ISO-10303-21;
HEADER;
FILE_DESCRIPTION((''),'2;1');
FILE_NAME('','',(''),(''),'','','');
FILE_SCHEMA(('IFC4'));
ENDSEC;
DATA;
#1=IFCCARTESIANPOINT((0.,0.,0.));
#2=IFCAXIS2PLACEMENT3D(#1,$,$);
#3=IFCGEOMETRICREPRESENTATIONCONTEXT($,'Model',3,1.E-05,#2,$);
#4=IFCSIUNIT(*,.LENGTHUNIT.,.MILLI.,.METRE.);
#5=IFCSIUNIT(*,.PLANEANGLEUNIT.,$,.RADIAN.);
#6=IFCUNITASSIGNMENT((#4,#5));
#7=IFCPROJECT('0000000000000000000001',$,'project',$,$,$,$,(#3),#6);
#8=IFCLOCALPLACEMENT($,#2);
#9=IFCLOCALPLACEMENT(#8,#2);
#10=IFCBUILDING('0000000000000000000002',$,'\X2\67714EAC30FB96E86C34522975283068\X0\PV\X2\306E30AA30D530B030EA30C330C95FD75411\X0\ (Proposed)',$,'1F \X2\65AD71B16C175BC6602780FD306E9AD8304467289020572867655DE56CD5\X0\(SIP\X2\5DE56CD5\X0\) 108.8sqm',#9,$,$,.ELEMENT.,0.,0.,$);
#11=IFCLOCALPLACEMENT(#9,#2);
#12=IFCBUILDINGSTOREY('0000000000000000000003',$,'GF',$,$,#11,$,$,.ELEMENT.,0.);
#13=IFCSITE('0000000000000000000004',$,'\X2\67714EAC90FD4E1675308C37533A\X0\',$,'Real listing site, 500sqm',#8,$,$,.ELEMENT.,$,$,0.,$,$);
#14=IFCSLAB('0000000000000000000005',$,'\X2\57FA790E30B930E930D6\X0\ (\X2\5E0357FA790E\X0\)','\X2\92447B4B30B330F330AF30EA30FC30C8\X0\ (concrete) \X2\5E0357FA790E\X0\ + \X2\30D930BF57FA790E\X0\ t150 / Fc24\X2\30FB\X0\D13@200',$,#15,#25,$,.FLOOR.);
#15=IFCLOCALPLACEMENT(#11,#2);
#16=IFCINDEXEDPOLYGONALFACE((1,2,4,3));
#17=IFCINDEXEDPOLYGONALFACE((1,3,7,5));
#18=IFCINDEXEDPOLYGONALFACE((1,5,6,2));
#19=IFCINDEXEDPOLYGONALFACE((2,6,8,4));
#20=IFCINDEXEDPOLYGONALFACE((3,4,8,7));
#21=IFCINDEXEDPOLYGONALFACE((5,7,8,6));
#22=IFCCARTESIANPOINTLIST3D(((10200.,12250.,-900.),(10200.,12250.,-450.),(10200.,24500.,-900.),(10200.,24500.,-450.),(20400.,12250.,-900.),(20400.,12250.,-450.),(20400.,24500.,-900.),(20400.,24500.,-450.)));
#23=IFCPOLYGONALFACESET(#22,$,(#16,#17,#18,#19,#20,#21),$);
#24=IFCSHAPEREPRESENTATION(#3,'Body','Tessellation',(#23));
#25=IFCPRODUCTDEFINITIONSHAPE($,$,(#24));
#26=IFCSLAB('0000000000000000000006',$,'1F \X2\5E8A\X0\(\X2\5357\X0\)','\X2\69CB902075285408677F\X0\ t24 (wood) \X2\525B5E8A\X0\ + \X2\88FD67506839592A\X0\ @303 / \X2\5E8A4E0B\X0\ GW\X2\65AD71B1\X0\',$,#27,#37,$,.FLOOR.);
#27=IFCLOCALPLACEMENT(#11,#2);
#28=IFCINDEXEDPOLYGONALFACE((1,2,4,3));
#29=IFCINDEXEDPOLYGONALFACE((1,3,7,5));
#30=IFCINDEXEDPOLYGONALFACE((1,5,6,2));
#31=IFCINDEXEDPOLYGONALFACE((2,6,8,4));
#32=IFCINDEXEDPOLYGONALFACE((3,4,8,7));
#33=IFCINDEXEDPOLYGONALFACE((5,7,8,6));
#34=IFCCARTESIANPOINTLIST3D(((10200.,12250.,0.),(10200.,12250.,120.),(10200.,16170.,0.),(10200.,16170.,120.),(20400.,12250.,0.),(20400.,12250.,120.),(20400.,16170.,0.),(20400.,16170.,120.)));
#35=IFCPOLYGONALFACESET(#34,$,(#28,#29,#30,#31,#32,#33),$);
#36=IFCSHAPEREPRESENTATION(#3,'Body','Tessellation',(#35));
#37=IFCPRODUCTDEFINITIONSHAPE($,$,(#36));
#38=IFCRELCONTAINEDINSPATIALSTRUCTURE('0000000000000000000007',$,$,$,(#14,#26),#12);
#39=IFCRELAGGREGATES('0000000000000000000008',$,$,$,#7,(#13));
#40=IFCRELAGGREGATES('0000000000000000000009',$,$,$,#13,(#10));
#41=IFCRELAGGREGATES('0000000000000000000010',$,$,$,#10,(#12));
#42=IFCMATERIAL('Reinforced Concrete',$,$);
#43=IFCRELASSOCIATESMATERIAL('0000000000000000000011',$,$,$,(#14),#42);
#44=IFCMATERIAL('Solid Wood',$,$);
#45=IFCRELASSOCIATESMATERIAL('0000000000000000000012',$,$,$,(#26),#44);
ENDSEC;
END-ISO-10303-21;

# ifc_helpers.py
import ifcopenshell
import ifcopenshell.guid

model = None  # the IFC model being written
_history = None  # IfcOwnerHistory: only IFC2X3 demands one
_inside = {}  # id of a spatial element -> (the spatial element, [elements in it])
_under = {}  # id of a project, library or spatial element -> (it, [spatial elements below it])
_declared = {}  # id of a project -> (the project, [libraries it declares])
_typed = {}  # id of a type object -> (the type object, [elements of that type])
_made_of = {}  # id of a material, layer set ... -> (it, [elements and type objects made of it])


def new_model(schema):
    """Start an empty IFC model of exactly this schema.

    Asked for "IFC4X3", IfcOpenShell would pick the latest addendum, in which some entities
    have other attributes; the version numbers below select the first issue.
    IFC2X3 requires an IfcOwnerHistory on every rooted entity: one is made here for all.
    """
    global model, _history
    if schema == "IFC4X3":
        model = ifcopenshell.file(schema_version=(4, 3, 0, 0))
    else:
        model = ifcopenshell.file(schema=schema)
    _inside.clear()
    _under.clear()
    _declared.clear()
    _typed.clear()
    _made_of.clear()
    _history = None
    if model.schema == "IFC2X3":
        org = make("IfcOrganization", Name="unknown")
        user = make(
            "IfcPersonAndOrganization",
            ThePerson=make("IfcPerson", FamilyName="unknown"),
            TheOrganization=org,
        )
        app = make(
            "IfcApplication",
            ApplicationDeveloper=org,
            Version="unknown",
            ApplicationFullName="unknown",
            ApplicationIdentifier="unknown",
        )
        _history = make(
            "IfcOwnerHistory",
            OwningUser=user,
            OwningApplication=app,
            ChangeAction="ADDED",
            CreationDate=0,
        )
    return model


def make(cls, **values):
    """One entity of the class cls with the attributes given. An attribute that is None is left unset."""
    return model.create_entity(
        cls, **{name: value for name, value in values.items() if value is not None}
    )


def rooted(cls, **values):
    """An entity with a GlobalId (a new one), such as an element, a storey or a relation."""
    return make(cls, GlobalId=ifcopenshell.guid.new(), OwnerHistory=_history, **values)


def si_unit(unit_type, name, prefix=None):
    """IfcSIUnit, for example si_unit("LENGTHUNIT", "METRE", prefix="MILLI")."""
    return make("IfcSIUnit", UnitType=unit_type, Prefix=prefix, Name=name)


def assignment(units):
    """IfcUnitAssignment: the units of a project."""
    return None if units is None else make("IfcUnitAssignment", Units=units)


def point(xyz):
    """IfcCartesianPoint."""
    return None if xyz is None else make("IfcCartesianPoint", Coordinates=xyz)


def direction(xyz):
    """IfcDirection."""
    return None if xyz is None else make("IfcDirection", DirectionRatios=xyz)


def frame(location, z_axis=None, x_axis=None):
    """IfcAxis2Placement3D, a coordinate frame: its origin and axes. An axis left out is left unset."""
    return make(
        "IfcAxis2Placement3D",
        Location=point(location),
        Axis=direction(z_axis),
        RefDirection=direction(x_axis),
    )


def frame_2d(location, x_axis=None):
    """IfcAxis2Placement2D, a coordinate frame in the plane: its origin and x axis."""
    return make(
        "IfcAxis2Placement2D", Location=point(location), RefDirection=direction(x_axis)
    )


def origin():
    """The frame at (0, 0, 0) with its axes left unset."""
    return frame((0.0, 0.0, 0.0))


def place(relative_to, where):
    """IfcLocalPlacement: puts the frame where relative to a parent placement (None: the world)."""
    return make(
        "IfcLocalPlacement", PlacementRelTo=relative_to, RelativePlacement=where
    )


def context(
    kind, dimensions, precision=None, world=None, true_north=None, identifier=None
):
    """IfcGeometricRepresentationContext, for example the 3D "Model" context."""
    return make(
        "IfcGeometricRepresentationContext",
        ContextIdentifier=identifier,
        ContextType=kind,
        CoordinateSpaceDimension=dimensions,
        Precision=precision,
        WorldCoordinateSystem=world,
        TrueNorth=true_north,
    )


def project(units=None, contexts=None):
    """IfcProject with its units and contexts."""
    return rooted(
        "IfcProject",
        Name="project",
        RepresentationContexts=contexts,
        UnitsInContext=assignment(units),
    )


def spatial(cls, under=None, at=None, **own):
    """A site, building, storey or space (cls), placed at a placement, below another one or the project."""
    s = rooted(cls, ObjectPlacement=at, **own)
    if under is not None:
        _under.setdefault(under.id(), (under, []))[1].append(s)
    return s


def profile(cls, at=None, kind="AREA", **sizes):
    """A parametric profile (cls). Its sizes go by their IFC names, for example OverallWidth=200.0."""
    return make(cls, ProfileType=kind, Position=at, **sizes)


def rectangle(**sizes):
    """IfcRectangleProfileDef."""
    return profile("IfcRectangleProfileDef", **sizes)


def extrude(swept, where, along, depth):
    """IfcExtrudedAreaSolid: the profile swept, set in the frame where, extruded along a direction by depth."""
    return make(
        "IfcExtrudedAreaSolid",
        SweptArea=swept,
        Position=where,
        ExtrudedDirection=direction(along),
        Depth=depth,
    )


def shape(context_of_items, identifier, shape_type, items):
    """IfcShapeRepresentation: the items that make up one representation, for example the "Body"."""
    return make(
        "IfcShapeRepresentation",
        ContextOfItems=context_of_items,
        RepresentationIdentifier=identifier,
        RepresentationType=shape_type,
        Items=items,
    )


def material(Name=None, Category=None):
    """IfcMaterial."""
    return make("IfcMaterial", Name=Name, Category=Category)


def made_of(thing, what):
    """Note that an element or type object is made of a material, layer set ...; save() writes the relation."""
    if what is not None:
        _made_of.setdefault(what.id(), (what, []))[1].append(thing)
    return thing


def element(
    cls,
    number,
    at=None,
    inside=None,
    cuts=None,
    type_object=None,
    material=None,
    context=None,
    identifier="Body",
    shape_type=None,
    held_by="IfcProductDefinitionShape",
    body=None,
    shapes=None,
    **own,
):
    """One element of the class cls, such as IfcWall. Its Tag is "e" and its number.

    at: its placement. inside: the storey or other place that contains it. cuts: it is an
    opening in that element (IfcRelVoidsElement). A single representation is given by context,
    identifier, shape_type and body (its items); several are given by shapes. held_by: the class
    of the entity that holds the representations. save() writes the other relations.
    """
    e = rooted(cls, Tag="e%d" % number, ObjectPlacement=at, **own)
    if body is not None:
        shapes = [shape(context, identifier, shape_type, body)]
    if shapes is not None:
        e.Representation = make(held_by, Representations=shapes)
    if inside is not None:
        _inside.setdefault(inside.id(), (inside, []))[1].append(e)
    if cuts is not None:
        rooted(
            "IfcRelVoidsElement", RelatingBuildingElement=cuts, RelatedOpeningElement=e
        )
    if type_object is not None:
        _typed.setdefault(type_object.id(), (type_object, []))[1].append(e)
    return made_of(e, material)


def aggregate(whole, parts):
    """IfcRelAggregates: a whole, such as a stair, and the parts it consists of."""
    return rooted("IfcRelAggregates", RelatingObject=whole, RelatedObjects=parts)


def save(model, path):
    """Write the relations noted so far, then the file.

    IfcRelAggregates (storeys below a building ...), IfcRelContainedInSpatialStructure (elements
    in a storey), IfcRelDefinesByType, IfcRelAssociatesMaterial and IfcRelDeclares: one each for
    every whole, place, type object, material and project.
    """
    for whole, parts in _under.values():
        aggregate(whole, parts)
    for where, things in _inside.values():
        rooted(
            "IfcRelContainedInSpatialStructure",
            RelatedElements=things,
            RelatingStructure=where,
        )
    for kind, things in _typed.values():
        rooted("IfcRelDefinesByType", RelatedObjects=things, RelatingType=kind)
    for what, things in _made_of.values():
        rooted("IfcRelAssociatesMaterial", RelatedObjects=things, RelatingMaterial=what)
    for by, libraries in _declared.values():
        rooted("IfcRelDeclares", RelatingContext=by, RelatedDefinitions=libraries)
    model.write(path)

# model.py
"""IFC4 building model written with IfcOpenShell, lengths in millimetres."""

from ifc_helpers import new_model, si_unit, frame, frame_2d, origin, place, context, project, spatial, rectangle, extrude, material, element, save


model = new_model("IFC4")

# Units and contexts
model_context = context("Model", 3, precision=1e-05, world=origin())
ifc_project = project(units=[si_unit("LENGTHUNIT", "METRE", prefix="MILLI"), si_unit("PLANEANGLEUNIT", "RADIAN")], contexts=[model_context])

# Site, building, storey
site_placement = place(None, origin())
site = spatial("IfcSite", under=ifc_project, at=site_placement, Name="東京都世田谷区", ObjectType="Real listing site, 500sqm", CompositionType="ELEMENT", RefElevation=0.0)
building_placement = place(site_placement, origin())
building = spatial("IfcBuilding", under=site, at=building_placement, Name="東京・雨水利用とPVのオフグリッド志向 (Proposed)", ObjectType="1F 断熱気密性能の高い木造在来工法(SIP工法) 108.8sqm", CompositionType="ELEMENT", ElevationOfRefHeight=0.0, ElevationOfTerrain=0.0)
storey_placement = place(building_placement, origin())
storey = spatial("IfcBuildingStorey", under=building, at=storey_placement, Name="GF", CompositionType="ELEMENT", Elevation=0.0)

# Shared definitions
ifc_material_1 = material(Name="Solid Wood")

# Slabs
ifc_material_2 = material(Name="Reinforced Concrete")
slab_1_placement = place(storey_placement, frame((5100.0, 6125.0, -450.0)))
element("IfcSlab", 1, at=slab_1_placement, inside=storey, material=ifc_material_2, Name="基礎スラブ (布基礎)", Description="鉄筋コンクリート (concrete) 布基礎 + ベタ基礎 t150 / Fc24・D13@200", PredefinedType="FLOOR", context=model_context, shape_type="SweptSolid", body=[
    extrude(rectangle(XDim=10200.0, YDim=12250.0, at=frame_2d((5100.0, 6125.0))), frame((5100.0, 6125.0, -450.0)), (0.0, 0.0, 1.0), 450.0),
])
slab_2_placement = place(storey_placement, frame((5100.0, 6125.0, 0.0)))
element("IfcSlab", 2, at=slab_2_placement, inside=storey, material=ifc_material_1, Name="1F 床(南)", Description="構造用合板 t24 (wood) 剛床 + 製材根太 @303 / 床下 GW断熱", PredefinedType="FLOOR", context=model_context, shape_type="SweptSolid", body=[
    extrude(rectangle(XDim=10200.0, YDim=3920.0, at=frame_2d((5100.0, 1960.0))), frame((5100.0, 6125.0, 0.0)), (0.0, 0.0, 1.0), 120.0),
])

save(model, "model.ifc")
